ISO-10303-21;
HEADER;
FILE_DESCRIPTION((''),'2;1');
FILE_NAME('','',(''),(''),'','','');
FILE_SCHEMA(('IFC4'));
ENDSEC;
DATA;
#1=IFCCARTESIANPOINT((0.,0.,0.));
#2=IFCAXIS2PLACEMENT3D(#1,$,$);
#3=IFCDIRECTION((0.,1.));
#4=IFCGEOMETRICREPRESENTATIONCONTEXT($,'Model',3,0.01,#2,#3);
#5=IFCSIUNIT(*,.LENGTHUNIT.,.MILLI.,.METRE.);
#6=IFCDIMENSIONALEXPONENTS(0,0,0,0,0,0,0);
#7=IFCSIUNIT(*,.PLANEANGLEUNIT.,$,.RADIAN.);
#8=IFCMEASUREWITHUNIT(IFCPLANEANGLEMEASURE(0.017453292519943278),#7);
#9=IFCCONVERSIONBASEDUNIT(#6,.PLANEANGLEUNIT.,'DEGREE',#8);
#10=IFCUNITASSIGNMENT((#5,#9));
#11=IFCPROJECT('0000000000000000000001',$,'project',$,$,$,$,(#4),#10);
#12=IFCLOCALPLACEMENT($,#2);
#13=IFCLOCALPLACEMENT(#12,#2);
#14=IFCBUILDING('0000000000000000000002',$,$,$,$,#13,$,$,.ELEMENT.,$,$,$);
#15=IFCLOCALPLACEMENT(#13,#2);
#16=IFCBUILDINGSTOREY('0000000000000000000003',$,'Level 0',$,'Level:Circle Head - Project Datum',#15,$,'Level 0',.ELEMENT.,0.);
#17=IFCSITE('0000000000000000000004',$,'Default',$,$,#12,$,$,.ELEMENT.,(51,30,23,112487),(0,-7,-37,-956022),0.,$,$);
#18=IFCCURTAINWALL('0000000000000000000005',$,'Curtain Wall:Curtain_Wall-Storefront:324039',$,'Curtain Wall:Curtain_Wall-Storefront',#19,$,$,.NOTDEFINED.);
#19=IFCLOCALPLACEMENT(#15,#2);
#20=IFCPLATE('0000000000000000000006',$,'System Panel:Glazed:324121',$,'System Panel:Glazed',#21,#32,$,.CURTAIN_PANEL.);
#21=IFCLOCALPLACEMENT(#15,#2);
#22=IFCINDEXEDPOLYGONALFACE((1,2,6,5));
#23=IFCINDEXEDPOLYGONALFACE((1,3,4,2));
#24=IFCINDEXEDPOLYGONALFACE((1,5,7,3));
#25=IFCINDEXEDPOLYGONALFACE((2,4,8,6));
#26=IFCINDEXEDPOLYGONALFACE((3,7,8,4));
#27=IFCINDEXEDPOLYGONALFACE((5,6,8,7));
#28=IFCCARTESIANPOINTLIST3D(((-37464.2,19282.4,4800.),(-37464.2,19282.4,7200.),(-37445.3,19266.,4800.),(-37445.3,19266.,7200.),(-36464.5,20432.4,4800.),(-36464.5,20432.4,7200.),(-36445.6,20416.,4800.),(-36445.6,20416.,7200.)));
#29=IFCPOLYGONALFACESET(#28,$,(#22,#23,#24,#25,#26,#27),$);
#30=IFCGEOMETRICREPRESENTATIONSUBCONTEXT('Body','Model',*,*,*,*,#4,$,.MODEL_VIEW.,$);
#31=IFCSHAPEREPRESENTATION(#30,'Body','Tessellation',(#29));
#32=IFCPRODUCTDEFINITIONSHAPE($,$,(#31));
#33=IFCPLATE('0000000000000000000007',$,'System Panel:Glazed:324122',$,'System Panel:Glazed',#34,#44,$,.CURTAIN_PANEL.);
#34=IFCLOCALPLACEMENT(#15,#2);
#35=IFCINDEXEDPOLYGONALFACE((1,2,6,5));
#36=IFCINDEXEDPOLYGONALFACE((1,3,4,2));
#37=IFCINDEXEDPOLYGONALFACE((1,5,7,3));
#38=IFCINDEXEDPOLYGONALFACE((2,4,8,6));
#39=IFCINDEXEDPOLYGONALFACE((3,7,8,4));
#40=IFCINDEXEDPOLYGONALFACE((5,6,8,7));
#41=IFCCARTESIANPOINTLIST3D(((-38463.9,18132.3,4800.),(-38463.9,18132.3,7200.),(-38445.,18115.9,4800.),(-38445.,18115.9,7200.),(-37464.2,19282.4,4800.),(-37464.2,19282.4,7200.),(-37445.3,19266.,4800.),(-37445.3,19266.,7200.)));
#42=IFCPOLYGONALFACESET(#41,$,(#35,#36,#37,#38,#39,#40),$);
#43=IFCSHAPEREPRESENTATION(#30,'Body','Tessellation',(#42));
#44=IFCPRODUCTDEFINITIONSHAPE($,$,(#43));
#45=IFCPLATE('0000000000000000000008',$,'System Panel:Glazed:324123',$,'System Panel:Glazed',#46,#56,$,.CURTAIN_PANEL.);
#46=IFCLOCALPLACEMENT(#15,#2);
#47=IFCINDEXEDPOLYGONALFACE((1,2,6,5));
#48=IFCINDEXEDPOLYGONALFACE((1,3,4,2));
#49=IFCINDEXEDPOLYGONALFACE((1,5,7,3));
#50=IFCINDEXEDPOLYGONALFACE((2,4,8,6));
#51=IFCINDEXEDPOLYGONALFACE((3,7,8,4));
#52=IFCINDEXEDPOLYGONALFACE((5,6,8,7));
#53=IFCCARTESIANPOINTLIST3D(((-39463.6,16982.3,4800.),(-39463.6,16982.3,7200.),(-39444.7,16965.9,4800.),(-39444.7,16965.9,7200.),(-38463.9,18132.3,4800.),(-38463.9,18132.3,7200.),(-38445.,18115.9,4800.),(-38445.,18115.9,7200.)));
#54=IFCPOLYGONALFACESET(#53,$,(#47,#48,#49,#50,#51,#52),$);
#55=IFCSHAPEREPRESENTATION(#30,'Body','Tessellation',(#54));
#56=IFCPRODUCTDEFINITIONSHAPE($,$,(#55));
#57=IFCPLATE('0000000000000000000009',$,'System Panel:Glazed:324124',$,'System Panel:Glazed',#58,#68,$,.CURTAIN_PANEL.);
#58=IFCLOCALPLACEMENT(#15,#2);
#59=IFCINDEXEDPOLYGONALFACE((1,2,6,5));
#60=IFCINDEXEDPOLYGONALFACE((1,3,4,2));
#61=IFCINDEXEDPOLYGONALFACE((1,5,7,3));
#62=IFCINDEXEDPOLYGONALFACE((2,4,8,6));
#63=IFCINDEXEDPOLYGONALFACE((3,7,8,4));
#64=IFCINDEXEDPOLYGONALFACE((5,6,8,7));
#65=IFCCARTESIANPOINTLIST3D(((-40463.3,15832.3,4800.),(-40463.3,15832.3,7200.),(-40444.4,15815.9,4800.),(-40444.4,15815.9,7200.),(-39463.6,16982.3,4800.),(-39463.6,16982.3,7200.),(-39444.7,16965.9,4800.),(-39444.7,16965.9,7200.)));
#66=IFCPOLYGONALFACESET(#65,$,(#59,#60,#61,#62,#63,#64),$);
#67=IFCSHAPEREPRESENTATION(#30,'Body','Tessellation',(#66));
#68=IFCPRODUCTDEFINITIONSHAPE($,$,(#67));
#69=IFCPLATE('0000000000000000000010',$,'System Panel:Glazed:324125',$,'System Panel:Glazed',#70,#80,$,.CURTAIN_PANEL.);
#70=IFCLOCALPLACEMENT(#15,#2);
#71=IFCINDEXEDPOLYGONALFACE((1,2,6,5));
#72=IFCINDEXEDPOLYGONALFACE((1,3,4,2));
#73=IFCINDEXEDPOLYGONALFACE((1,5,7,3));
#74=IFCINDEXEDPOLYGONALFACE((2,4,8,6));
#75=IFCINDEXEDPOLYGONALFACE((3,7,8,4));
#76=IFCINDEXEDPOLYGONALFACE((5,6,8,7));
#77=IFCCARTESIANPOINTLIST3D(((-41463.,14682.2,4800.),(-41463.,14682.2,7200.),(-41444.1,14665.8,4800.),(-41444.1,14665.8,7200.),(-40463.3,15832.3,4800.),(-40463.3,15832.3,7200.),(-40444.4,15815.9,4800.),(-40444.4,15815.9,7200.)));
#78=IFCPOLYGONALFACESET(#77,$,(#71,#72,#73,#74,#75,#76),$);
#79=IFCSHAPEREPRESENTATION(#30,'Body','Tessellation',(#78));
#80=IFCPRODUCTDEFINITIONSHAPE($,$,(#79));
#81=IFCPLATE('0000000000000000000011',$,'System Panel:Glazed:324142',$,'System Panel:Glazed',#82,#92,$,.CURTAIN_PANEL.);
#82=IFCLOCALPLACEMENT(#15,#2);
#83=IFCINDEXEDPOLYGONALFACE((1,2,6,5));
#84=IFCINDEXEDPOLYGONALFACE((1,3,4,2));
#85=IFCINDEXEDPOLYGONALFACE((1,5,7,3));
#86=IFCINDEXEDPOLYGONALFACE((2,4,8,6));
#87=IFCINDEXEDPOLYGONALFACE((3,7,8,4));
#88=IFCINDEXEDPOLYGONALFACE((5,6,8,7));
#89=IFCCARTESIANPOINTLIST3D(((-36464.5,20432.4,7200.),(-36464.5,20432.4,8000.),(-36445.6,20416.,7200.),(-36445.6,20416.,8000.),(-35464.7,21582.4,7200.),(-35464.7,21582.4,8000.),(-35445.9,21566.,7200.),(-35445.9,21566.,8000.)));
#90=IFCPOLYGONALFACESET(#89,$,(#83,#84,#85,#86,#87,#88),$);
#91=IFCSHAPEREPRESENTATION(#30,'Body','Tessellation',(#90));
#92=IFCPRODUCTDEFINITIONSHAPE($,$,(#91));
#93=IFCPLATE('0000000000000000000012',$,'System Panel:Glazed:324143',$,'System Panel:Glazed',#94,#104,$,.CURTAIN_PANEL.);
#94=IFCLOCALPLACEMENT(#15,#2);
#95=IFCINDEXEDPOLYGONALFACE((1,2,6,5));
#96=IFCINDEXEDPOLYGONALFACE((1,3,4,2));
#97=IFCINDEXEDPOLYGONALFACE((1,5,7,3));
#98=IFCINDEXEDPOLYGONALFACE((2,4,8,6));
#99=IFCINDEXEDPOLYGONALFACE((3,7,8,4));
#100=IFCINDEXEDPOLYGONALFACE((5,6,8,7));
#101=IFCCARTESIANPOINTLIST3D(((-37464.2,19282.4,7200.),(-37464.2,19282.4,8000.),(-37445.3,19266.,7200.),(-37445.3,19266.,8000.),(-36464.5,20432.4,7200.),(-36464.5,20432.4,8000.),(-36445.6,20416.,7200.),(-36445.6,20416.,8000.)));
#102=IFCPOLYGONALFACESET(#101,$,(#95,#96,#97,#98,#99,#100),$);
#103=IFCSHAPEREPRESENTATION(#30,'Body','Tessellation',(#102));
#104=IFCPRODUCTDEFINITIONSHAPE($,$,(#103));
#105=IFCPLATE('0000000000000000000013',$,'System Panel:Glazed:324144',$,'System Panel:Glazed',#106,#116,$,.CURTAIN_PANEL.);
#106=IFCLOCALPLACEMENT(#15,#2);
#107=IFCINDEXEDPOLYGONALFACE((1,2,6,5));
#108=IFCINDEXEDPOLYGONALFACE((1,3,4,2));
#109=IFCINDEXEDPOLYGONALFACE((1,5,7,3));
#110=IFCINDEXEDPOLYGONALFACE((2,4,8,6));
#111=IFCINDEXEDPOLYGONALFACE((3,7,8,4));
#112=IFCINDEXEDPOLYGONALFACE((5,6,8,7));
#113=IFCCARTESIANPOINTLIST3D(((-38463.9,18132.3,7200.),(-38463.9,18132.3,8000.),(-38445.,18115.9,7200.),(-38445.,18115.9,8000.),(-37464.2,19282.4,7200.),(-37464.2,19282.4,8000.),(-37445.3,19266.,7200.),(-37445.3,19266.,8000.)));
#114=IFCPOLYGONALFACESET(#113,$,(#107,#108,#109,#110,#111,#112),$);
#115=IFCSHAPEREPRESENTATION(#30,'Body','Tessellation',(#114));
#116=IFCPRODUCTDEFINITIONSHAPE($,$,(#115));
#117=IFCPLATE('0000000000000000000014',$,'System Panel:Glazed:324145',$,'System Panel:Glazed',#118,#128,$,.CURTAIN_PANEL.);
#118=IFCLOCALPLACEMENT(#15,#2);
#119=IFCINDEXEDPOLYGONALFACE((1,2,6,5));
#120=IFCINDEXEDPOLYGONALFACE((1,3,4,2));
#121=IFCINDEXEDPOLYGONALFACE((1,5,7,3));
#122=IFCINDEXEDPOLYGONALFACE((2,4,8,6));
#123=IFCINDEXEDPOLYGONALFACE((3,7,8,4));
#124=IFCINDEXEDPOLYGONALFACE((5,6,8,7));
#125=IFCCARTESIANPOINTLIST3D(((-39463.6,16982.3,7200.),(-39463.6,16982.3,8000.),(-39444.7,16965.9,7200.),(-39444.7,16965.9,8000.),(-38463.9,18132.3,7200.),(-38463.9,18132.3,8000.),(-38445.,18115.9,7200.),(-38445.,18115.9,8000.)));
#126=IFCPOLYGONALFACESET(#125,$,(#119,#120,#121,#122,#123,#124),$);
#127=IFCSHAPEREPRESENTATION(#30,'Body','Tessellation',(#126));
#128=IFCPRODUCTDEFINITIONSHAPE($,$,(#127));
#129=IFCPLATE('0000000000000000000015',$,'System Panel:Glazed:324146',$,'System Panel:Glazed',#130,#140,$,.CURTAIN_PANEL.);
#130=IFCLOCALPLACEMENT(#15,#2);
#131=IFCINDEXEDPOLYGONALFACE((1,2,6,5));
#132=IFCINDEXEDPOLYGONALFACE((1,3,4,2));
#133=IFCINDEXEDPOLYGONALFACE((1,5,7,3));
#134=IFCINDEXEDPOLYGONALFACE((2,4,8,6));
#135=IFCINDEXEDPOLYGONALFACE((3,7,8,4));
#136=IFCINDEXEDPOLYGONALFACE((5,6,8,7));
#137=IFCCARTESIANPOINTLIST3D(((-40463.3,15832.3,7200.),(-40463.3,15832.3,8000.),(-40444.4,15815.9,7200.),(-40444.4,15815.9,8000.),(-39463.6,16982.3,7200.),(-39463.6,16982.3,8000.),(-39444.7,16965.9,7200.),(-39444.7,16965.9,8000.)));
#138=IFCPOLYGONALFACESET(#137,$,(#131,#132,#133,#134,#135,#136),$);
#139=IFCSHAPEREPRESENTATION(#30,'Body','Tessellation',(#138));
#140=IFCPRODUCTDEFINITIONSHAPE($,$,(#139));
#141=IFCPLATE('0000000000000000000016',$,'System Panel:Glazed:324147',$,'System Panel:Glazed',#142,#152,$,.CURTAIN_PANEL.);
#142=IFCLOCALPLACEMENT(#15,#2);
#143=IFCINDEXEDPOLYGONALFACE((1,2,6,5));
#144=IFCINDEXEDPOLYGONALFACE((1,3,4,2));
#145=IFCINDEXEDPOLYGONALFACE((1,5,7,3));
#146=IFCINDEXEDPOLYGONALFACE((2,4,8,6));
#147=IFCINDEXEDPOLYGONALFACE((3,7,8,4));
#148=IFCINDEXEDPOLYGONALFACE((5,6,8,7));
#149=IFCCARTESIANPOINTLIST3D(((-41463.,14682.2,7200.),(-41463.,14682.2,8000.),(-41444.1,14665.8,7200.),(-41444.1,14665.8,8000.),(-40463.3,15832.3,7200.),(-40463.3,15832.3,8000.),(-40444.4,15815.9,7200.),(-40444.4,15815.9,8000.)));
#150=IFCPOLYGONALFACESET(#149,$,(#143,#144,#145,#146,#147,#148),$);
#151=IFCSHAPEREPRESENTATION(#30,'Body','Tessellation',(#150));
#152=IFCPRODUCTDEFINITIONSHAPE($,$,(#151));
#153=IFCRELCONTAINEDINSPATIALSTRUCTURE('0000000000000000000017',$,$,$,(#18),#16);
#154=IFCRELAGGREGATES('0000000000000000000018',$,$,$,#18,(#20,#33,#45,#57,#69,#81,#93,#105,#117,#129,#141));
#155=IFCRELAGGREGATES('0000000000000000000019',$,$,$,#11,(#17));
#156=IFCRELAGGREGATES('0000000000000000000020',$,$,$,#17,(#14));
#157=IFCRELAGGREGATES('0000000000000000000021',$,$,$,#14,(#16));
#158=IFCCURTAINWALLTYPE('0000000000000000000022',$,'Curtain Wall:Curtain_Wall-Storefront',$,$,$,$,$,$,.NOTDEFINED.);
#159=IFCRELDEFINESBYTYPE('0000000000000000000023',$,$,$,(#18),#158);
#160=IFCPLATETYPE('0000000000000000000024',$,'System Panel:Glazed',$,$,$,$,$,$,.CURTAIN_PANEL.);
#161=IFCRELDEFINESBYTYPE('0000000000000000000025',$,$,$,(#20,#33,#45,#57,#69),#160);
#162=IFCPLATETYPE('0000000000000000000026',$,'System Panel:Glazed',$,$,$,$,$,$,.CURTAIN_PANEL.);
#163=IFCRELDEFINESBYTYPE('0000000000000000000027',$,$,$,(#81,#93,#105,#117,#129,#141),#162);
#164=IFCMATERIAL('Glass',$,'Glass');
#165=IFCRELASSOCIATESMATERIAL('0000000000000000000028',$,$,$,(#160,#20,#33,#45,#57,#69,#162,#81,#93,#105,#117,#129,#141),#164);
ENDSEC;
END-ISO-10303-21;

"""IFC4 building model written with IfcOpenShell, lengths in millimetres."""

from ifc_helpers import new_model, entity, si_unit, converted_unit, direction, frame, origin, place, context, subcontext, project, spatial, indexed_curve, outline, extrude, source, transform, mapped, material, type_object, type_shapes, element, aggregate, save


model = new_model("IFC4")

# Units and contexts
model_context = context("Model", 3, precision=0.01, world=origin(), true_north=direction((0.0, 1.0)))
body_context = subcontext(model_context, "Body", "Model", "MODEL_VIEW")
ifc_project = project(units=[si_unit("LENGTHUNIT", "METRE", prefix="MILLI"), converted_unit("PLANEANGLEUNIT", "DEGREE", entity("IfcPlaneAngleMeasure", 0.017453292519943278), si_unit("PLANEANGLEUNIT", "RADIAN"), dimensions=[0, 0, 0, 0, 0, 0, 0])], contexts=[model_context])

# Site, building, storey
site_placement = place(None, origin())
site = spatial("IfcSite", under=ifc_project, at=site_placement, Name="Default", CompositionType="ELEMENT", RefLatitude=(51, 30, 23, 112487), RefLongitude=(0, -7, -37, -956022), RefElevation=0.0)
building_placement = place(site_placement, origin())
building = spatial("IfcBuilding", under=site, at=building_placement, CompositionType="ELEMENT")
storey_placement = place(building_placement, origin())
storey = spatial("IfcBuildingStorey", under=building, at=storey_placement, Name="Level 0", ObjectType="Level:Circle Head - Project Datum", LongName="Level 0", CompositionType="ELEMENT", Elevation=0.0)

# Curtain wall, plates
curtain_wall_type = type_object("IfcCurtainWallType", Name="Curtain Wall:Curtain_Wall-Storefront", PredefinedType="NOTDEFINED")
curtain_wall_placement = place(storey_placement, origin())
curtain_wall = element("IfcCurtainWall", 1, at=curtain_wall_placement, inside=storey, type_object=curtain_wall_type, Name="Curtain Wall:Curtain_Wall-Storefront:324039", ObjectType="Curtain Wall:Curtain_Wall-Storefront", PredefinedType="NOTDEFINED")
ifc_material = material(Name="Glass", Category="Glass")
plate_type_1 = type_object("IfcPlateType", Name="System Panel:Glazed", PredefinedType="CURTAIN_PANEL", material=ifc_material)
shared_shape_1 = source(origin(), body_context, "Body", "SweptSolid", [
    extrude(outline(indexed_curve([(-12.5, -761.9), (12.5, -761.9), (12.5, 761.9), (-12.5, 761.9), (-12.5, -761.9)], self_intersect=False)), frame((0.0, 37.0, 0.0), z_axis=(0.0, 0.0, 1.0), x_axis=(0.0, 1.0, 0.0)), (0.0, 0.0, 1.0), 2400.0),
])
type_shapes(plate_type_1, [shared_shape_1])
plate_1_placement = place(curtain_wall_placement, frame((-36982.8, 19873.5, 4800.0), z_axis=(0.0, 0.0, 1.0), x_axis=(-0.656059, -0.75471, 0.0)))
plate_1 = element("IfcPlate", 2, at=plate_1_placement, type_object=plate_type_1, material=ifc_material, Name="System Panel:Glazed:324121", ObjectType="System Panel:Glazed", PredefinedType="CURTAIN_PANEL", context=body_context, shape_type="MappedRepresentation", body=[
    mapped(shared_shape_1, transform((0.0, 0.0, 0.0), scale=1.0)),
])
plate_2_placement = place(curtain_wall_placement, frame((-37982.5, 18723.4, 4800.0), z_axis=(0.0, 0.0, 1.0), x_axis=(-0.656059, -0.75471, 0.0)))
plate_2 = element("IfcPlate", 3, at=plate_2_placement, type_object=plate_type_1, material=ifc_material, Name="System Panel:Glazed:324122", ObjectType="System Panel:Glazed", PredefinedType="CURTAIN_PANEL", context=body_context, shape_type="MappedRepresentation", body=[
    mapped(shared_shape_1, transform((0.0, 0.0, 0.0), scale=1.0)),
])
plate_3_placement = place(curtain_wall_placement, frame((-38982.2, 17573.4, 4800.0), z_axis=(0.0, 0.0, 1.0), x_axis=(-0.656059, -0.75471, 0.0)))
plate_3 = element("IfcPlate", 4, at=plate_3_placement, type_object=plate_type_1, material=ifc_material, Name="System Panel:Glazed:324123", ObjectType="System Panel:Glazed", PredefinedType="CURTAIN_PANEL", context=body_context, shape_type="MappedRepresentation", body=[
    mapped(shared_shape_1, transform((0.0, 0.0, 0.0), scale=1.0)),
])
plate_4_placement = place(curtain_wall_placement, frame((-39981.9, 16423.4, 4800.0), z_axis=(0.0, 0.0, 1.0), x_axis=(-0.656059, -0.75471, 0.0)))
plate_4 = element("IfcPlate", 5, at=plate_4_placement, type_object=plate_type_1, material=ifc_material, Name="System Panel:Glazed:324124", ObjectType="System Panel:Glazed", PredefinedType="CURTAIN_PANEL", context=body_context, shape_type="MappedRepresentation", body=[
    mapped(shared_shape_1, transform((0.0, 0.0, 0.0), scale=1.0)),
])
plate_5_placement = place(curtain_wall_placement, frame((-40981.6, 15273.3, 4800.0), z_axis=(0.0, 0.0, 1.0), x_axis=(-0.656059, -0.75471, 0.0)))
plate_5 = element("IfcPlate", 6, at=plate_5_placement, type_object=plate_type_1, material=ifc_material, Name="System Panel:Glazed:324125", ObjectType="System Panel:Glazed", PredefinedType="CURTAIN_PANEL", context=body_context, shape_type="MappedRepresentation", body=[
    mapped(shared_shape_1, transform((0.0, 0.0, 0.0), scale=1.0)),
])
plate_type_2 = type_object("IfcPlateType", Name="System Panel:Glazed", PredefinedType="CURTAIN_PANEL", material=ifc_material)
shared_shape_2 = source(origin(), body_context, "Body", "SweptSolid", [
    extrude(outline(indexed_curve([(-12.5, -761.9), (12.5, -761.9), (12.5, 761.9), (-12.5, 761.9), (-12.5, -761.9)], self_intersect=False)), frame((0.0, 37.0, 0.0), z_axis=(0.0, 0.0, 1.0), x_axis=(0.0, 1.0, 0.0)), (0.0, 0.0, 1.0), 800.0),
])
type_shapes(plate_type_2, [shared_shape_2])
plate_6_placement = place(curtain_wall_placement, frame((-35983.1, 21023.5, 7200.0), z_axis=(0.0, 0.0, 1.0), x_axis=(-0.656059, -0.75471, 0.0)))
plate_6 = element("IfcPlate", 7, at=plate_6_placement, type_object=plate_type_2, material=ifc_material, Name="System Panel:Glazed:324142", ObjectType="System Panel:Glazed", PredefinedType="CURTAIN_PANEL", context=body_context, shape_type="MappedRepresentation", body=[
    mapped(shared_shape_2, transform((0.0, 0.0, 0.0), scale=1.0)),
])
plate_7_placement = place(curtain_wall_placement, frame((-36982.8, 19873.5, 7200.0), z_axis=(0.0, 0.0, 1.0), x_axis=(-0.656059, -0.75471, 0.0)))
plate_7 = element("IfcPlate", 8, at=plate_7_placement, type_object=plate_type_2, material=ifc_material, Name="System Panel:Glazed:324143", ObjectType="System Panel:Glazed", PredefinedType="CURTAIN_PANEL", context=body_context, shape_type="MappedRepresentation", body=[
    mapped(shared_shape_2, transform((0.0, 0.0, 0.0), scale=1.0)),
])
plate_8_placement = place(curtain_wall_placement, frame((-37982.5, 18723.4, 7200.0), z_axis=(0.0, 0.0, 1.0), x_axis=(-0.656059, -0.75471, 0.0)))
plate_8 = element("IfcPlate", 9, at=plate_8_placement, type_object=plate_type_2, material=ifc_material, Name="System Panel:Glazed:324144", ObjectType="System Panel:Glazed", PredefinedType="CURTAIN_PANEL", context=body_context, shape_type="MappedRepresentation", body=[
    mapped(shared_shape_2, transform((0.0, 0.0, 0.0), scale=1.0)),
])
plate_9_placement = place(curtain_wall_placement, frame((-38982.2, 17573.4, 7200.0), z_axis=(0.0, 0.0, 1.0), x_axis=(-0.656059, -0.75471, 0.0)))
plate_9 = element("IfcPlate", 10, at=plate_9_placement, type_object=plate_type_2, material=ifc_material, Name="System Panel:Glazed:324145", ObjectType="System Panel:Glazed", PredefinedType="CURTAIN_PANEL", context=body_context, shape_type="MappedRepresentation", body=[
    mapped(shared_shape_2, transform((0.0, 0.0, 0.0), scale=1.0)),
])
plate_10_placement = place(curtain_wall_placement, frame((-39981.9, 16423.4, 7200.0), z_axis=(0.0, 0.0, 1.0), x_axis=(-0.656059, -0.75471, 0.0)))
plate_10 = element("IfcPlate", 11, at=plate_10_placement, type_object=plate_type_2, material=ifc_material, Name="System Panel:Glazed:324146", ObjectType="System Panel:Glazed", PredefinedType="CURTAIN_PANEL", context=body_context, shape_type="MappedRepresentation", body=[
    mapped(shared_shape_2, transform((0.0, 0.0, 0.0), scale=1.0)),
])
plate_11_placement = place(curtain_wall_placement, frame((-40981.6, 15273.3, 7200.0), z_axis=(0.0, 0.0, 1.0), x_axis=(-0.656059, -0.75471, 0.0)))
plate_11 = element("IfcPlate", 12, at=plate_11_placement, type_object=plate_type_2, material=ifc_material, Name="System Panel:Glazed:324147", ObjectType="System Panel:Glazed", PredefinedType="CURTAIN_PANEL", context=body_context, shape_type="MappedRepresentation", body=[
    mapped(shared_shape_2, transform((0.0, 0.0, 0.0), scale=1.0)),
])
aggregate(curtain_wall, [plate_1, plate_2, plate_3, plate_4, plate_5, plate_6, plate_7, plate_8, plate_9, plate_10, plate_11])

save(model, "model.ifc")
